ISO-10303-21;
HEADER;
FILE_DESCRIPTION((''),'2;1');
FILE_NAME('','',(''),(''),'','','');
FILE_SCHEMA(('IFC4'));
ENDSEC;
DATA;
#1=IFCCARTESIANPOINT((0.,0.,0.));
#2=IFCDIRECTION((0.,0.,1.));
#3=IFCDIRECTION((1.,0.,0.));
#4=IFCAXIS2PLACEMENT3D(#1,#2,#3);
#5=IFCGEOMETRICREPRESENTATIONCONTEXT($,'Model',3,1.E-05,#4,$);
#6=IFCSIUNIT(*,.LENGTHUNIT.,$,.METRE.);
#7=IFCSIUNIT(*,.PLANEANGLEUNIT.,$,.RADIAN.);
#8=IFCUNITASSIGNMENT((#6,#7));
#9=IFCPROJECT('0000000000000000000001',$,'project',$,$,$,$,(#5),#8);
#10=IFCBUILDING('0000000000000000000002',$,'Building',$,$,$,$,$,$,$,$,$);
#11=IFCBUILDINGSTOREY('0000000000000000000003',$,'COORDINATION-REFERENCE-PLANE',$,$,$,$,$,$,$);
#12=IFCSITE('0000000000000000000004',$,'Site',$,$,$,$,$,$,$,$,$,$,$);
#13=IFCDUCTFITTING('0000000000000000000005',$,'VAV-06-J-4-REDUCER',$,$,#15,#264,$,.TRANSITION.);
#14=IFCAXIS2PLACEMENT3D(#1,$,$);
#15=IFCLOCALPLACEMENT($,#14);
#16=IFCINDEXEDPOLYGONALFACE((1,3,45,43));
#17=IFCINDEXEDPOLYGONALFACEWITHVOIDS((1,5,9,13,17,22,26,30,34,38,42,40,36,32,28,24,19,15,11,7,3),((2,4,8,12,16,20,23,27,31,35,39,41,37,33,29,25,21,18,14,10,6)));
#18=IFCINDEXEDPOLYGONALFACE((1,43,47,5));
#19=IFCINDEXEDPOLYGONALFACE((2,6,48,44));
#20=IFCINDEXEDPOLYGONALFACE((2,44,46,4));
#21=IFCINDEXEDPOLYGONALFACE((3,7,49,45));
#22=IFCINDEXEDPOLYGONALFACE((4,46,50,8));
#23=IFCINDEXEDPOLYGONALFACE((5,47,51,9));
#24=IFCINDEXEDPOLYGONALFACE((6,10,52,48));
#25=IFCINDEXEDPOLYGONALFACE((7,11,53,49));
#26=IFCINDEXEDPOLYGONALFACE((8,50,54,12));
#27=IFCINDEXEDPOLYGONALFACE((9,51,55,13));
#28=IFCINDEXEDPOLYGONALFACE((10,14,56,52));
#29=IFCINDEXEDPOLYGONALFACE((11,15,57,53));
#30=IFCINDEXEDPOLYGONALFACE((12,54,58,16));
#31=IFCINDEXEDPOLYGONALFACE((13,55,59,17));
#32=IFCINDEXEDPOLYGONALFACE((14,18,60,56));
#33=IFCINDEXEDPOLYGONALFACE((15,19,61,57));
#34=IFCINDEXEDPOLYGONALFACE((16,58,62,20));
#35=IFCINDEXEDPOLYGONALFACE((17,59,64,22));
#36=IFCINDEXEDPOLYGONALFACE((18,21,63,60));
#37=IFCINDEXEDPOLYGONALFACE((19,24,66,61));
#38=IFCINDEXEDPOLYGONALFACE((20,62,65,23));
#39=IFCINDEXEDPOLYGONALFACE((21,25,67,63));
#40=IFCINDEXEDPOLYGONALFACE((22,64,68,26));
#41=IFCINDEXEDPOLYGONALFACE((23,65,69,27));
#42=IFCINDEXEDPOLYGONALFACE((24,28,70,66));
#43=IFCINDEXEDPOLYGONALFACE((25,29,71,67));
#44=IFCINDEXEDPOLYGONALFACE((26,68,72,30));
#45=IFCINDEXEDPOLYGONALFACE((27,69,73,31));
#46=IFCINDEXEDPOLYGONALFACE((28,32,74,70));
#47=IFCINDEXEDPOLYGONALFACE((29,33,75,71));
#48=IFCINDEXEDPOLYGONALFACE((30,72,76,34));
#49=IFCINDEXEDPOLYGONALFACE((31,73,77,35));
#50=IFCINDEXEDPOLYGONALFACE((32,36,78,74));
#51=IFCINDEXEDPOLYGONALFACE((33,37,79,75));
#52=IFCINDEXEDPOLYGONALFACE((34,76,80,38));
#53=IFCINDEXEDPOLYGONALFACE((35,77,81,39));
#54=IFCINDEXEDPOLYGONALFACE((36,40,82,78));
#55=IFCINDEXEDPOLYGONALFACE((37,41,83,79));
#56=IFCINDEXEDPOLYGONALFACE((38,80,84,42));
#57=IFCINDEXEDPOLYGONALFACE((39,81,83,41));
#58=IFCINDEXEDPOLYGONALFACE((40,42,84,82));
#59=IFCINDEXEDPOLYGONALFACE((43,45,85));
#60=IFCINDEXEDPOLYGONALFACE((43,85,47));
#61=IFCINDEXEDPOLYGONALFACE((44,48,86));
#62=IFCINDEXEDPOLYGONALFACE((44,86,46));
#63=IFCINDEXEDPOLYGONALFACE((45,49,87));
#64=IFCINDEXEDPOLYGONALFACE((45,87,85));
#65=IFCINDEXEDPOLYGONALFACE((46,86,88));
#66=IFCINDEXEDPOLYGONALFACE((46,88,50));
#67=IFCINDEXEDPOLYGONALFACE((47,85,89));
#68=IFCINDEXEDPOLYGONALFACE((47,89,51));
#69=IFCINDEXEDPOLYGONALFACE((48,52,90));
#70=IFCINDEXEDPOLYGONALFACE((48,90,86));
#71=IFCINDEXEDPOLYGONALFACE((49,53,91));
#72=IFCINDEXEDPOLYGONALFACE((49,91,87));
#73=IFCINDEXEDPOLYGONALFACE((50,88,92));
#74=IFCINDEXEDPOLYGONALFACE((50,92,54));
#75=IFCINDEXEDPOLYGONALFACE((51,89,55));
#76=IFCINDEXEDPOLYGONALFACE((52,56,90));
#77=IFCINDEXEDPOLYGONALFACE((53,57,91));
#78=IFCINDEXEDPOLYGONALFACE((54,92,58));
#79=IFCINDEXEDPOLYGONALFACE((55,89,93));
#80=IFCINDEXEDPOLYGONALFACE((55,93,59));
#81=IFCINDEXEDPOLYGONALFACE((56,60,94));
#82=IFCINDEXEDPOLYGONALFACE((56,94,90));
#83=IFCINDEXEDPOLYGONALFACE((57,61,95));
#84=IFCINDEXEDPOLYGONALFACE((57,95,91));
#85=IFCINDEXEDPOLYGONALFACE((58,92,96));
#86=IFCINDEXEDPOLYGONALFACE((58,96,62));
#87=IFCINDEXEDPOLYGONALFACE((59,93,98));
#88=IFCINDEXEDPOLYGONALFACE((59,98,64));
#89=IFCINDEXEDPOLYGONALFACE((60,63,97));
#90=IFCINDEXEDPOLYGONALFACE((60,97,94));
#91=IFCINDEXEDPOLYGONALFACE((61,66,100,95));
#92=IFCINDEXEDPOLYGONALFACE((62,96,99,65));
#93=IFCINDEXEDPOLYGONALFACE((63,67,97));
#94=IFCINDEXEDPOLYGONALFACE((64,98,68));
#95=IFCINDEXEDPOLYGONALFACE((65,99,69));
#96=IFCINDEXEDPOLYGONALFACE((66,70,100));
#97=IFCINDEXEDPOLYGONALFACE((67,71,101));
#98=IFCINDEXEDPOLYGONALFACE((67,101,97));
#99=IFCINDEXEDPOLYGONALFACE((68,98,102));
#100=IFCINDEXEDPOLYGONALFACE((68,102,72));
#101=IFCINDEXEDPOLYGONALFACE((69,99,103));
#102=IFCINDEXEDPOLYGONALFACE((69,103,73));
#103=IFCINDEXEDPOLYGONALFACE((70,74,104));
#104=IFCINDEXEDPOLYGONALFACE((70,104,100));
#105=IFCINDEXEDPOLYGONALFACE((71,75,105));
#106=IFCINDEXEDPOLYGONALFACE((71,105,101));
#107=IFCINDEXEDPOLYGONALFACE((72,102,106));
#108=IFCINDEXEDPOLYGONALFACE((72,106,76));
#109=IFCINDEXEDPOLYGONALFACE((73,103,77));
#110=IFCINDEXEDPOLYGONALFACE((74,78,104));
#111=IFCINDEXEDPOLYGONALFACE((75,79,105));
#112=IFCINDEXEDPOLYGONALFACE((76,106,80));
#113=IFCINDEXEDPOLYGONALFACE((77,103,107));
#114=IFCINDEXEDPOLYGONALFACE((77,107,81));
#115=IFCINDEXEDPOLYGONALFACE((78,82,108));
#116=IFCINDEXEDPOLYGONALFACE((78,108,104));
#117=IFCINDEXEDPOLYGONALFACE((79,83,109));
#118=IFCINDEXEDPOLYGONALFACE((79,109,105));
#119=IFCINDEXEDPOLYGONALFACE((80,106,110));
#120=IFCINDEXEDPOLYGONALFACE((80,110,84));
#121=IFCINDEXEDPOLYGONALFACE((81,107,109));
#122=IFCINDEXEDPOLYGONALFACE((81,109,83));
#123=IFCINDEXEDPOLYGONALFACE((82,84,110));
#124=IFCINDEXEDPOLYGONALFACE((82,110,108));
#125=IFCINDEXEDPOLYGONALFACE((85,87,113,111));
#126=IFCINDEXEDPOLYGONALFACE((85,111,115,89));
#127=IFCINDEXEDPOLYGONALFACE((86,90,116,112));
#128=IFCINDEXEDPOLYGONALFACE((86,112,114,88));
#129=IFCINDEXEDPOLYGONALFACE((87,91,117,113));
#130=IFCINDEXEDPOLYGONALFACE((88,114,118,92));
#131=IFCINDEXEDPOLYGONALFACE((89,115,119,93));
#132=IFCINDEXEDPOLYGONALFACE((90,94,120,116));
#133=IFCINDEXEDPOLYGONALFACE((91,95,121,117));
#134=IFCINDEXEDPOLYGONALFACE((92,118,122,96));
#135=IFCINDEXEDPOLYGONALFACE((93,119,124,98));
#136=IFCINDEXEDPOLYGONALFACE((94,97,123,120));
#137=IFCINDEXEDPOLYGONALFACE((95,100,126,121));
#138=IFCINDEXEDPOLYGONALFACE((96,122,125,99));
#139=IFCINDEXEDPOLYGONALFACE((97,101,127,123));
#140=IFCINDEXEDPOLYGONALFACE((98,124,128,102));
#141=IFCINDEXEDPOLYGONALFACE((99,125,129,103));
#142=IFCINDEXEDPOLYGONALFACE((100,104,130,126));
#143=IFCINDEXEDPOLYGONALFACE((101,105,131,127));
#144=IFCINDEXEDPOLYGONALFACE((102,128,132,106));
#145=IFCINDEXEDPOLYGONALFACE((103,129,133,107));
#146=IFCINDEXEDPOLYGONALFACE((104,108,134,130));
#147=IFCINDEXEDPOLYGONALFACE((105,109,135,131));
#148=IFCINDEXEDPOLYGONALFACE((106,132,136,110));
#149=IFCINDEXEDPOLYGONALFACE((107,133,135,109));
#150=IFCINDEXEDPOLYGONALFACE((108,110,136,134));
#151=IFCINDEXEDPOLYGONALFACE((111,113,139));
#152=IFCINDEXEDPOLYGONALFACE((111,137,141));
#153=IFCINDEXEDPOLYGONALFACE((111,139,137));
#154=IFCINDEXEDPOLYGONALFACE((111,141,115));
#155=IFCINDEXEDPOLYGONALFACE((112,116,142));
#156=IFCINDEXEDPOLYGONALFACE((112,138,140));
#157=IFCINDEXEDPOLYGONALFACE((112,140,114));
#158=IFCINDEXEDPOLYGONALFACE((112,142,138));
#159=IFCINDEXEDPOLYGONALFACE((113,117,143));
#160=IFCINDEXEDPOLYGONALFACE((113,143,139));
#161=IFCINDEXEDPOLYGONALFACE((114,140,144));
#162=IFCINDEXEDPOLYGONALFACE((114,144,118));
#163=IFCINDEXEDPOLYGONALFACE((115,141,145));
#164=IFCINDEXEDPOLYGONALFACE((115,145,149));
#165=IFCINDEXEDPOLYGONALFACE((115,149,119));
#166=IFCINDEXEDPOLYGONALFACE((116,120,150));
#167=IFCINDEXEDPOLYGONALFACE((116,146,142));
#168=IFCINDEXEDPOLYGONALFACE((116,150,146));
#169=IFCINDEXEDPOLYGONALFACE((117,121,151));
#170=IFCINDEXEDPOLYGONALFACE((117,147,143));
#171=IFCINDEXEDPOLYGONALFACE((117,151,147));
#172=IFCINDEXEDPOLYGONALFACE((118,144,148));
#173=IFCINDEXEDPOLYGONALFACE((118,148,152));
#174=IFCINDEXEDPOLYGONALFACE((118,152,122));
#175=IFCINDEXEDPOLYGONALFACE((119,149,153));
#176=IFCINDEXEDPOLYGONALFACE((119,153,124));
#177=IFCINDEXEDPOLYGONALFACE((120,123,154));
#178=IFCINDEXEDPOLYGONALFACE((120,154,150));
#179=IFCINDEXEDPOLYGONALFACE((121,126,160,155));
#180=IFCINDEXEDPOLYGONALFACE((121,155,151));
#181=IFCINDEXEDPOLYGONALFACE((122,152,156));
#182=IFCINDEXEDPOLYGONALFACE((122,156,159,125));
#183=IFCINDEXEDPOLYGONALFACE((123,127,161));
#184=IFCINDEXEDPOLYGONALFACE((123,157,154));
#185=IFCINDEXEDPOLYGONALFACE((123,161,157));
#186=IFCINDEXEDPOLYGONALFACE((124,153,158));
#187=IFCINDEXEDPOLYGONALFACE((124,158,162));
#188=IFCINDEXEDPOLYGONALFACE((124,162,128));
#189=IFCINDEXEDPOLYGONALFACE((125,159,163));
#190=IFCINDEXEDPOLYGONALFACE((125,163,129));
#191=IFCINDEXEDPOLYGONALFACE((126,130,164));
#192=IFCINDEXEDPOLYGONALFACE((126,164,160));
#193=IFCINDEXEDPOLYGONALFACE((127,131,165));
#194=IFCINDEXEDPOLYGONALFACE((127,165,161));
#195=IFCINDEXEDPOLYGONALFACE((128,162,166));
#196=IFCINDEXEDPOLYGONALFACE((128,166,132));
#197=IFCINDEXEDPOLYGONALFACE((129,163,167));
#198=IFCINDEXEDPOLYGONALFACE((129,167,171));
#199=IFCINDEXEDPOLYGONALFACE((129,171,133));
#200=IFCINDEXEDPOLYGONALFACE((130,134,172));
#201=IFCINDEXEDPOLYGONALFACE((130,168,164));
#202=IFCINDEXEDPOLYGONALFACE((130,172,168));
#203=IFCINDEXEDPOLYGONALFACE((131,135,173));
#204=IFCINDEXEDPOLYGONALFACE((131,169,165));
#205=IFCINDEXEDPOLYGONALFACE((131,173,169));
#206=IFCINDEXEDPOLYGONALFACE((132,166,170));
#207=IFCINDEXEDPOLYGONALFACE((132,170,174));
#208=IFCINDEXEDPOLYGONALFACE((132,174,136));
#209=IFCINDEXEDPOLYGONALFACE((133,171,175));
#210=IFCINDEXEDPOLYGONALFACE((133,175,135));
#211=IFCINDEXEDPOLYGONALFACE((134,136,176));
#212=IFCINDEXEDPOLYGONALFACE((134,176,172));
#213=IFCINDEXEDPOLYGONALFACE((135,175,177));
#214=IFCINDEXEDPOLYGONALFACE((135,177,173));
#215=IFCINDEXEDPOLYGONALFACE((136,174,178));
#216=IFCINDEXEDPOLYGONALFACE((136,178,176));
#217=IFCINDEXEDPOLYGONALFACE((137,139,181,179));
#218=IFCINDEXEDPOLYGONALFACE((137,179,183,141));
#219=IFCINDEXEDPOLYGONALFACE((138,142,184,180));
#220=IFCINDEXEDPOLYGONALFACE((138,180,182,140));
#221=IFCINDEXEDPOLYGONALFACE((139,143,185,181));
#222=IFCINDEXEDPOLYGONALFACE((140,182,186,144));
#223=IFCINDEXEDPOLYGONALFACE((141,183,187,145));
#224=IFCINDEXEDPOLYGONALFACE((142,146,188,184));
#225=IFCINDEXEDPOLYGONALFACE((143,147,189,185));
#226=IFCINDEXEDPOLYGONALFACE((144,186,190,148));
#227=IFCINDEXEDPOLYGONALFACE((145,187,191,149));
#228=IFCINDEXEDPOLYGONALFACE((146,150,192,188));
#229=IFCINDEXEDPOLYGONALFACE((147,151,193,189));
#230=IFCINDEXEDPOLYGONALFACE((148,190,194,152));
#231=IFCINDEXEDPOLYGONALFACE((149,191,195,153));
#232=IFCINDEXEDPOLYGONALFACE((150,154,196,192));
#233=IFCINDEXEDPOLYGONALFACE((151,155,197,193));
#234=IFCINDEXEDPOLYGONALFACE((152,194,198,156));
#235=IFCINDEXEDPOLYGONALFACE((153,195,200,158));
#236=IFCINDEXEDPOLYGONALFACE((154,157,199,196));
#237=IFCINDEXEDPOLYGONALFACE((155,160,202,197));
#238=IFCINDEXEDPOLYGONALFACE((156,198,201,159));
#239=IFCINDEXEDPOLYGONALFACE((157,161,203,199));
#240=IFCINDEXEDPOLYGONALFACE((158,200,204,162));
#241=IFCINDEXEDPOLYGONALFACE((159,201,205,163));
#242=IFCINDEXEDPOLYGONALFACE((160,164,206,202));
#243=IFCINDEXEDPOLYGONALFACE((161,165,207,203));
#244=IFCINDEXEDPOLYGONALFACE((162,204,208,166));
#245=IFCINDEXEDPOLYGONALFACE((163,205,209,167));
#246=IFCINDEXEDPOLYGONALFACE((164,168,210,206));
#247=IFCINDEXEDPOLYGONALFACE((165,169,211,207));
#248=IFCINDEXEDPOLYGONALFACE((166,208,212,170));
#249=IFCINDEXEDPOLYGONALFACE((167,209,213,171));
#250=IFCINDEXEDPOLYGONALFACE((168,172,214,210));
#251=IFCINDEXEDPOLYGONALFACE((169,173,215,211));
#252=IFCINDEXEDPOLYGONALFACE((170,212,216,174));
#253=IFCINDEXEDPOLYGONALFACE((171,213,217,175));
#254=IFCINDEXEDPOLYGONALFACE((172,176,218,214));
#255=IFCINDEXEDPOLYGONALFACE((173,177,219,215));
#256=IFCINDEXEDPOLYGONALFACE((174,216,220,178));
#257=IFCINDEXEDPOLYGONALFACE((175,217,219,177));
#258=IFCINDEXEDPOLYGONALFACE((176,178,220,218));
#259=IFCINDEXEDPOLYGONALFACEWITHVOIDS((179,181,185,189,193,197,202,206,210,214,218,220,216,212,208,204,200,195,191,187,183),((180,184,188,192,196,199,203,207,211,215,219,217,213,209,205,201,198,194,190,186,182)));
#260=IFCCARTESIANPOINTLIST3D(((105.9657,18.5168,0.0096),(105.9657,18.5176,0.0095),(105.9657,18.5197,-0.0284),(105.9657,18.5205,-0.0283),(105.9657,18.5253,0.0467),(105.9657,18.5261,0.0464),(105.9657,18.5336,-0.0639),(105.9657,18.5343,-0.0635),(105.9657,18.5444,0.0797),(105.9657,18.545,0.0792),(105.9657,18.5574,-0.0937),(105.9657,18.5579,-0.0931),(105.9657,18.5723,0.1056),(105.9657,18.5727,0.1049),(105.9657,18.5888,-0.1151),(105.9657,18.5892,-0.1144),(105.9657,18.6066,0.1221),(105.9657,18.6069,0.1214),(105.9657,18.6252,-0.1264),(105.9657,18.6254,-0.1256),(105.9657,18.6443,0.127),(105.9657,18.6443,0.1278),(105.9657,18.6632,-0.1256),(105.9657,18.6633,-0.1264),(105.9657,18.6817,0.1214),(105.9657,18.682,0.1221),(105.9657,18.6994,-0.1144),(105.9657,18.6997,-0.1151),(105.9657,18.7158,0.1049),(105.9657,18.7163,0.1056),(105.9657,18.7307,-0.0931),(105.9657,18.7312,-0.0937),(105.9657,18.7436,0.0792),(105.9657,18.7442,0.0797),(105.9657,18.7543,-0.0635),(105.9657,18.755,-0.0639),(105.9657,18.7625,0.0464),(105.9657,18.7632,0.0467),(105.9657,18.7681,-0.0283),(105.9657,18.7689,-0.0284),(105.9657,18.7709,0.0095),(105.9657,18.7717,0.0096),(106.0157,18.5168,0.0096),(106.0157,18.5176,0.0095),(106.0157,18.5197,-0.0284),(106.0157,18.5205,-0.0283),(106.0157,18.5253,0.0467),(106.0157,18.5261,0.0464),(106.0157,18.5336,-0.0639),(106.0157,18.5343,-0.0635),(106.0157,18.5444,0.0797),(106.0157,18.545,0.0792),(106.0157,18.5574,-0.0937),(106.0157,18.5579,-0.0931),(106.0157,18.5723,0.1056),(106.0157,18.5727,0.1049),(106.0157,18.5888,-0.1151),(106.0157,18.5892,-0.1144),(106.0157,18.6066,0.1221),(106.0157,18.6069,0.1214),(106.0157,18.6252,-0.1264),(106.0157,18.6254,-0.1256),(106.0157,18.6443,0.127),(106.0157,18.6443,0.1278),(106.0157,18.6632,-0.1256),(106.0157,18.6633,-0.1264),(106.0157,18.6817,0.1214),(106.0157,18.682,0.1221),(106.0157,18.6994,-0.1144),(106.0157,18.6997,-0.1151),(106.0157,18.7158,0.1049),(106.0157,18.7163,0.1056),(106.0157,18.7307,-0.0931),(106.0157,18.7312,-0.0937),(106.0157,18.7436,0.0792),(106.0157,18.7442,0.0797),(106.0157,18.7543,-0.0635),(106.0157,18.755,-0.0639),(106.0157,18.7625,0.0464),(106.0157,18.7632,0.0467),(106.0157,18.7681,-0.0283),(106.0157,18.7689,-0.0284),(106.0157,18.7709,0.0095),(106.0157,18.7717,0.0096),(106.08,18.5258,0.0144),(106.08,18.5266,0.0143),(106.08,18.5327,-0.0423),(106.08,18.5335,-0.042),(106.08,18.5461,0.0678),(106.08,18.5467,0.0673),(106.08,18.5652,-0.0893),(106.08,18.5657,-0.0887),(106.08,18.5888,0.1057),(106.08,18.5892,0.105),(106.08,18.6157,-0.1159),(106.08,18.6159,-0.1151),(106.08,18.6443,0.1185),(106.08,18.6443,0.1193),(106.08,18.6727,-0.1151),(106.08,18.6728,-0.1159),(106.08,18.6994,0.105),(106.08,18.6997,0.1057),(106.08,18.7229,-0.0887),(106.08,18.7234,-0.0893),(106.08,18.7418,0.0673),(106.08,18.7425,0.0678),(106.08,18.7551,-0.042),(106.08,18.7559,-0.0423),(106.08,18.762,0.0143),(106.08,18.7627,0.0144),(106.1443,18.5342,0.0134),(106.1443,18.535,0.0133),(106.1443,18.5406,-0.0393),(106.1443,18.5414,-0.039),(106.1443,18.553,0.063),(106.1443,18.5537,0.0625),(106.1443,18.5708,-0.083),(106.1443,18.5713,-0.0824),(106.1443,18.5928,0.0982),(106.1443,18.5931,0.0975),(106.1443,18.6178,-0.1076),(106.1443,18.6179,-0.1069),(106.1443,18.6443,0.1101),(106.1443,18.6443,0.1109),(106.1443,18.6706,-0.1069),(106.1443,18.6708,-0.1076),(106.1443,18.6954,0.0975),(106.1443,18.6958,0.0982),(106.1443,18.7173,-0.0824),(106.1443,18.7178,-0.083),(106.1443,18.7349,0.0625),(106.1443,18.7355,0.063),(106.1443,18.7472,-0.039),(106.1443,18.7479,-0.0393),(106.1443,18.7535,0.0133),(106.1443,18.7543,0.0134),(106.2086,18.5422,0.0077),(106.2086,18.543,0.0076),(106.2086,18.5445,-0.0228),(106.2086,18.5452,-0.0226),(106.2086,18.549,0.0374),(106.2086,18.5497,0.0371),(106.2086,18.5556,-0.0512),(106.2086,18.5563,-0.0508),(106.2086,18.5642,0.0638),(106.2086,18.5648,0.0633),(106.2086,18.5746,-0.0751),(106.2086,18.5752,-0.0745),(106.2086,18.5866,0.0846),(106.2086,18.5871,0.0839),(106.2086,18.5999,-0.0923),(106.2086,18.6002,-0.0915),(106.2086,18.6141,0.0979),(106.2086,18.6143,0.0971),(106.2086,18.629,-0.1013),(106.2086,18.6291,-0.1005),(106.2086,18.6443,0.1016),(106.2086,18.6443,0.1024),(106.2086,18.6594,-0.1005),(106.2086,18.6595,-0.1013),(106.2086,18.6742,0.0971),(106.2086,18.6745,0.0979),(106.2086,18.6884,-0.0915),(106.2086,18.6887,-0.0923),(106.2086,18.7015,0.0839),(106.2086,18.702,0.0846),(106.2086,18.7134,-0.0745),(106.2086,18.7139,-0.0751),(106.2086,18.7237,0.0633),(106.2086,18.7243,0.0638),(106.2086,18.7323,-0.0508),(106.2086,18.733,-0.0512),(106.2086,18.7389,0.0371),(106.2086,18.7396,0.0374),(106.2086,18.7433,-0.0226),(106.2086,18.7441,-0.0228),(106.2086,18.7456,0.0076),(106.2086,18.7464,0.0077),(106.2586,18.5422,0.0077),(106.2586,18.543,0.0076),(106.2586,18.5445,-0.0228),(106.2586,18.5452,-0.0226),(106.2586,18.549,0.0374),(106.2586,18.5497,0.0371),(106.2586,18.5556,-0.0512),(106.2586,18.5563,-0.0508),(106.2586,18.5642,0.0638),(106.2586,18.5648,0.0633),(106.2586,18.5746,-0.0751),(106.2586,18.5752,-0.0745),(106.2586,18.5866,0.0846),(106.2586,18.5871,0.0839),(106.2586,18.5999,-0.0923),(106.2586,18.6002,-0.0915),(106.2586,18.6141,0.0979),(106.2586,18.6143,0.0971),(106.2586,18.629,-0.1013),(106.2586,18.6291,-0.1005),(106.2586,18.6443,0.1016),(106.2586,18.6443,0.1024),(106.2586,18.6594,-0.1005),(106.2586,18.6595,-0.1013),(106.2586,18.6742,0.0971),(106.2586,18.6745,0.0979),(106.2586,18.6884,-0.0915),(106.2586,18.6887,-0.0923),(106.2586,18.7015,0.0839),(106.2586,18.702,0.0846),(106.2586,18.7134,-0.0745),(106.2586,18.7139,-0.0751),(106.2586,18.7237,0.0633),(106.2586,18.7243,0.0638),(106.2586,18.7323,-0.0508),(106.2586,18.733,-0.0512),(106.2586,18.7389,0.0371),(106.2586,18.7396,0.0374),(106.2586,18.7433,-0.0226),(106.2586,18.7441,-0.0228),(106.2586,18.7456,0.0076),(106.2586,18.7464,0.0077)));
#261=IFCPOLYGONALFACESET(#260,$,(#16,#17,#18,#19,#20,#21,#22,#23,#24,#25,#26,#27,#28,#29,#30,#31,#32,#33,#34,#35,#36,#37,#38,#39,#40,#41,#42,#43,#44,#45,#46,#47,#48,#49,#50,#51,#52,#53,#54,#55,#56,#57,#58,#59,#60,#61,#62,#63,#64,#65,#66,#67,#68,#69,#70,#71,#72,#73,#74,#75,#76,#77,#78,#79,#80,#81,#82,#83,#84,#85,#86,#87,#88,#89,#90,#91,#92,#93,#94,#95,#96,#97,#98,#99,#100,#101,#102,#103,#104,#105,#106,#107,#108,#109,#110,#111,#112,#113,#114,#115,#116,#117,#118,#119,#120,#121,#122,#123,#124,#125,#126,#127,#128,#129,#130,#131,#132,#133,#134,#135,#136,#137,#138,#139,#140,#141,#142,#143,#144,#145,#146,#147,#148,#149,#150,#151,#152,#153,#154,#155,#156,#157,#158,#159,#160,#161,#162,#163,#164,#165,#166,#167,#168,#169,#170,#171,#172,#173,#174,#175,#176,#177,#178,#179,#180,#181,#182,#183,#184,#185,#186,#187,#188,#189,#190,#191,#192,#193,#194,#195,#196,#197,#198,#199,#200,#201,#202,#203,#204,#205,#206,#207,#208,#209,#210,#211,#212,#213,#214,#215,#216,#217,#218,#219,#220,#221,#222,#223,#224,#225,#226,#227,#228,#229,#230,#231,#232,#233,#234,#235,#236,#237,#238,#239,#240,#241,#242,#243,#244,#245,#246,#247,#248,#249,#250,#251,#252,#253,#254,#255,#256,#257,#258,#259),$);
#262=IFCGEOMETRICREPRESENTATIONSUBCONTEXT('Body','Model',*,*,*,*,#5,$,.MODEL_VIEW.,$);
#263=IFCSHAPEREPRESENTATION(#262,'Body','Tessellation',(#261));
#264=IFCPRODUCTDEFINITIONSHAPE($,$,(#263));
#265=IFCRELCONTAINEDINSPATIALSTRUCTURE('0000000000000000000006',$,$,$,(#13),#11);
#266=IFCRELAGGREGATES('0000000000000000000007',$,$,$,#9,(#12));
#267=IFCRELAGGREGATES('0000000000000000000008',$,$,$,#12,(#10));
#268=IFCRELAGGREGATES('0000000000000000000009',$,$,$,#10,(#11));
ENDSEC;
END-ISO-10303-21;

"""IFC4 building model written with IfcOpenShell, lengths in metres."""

from ifc_helpers import new_model, entity, si_unit, frame, origin_with_axes, place, context, subcontext, project, spatial, element, save


model = new_model("IFC4")

# Units and contexts
model_context_1 = context("Model", 3, precision=1e-05, world=origin_with_axes())
body_context_1 = subcontext(model_context_1, "Body", "Model", "MODEL_VIEW")
ifc_project = project(units=[si_unit("LENGTHUNIT", "METRE"), si_unit("PLANEANGLEUNIT", "RADIAN")], contexts=[model_context_1])

# Site, building, storey
site = spatial("IfcSite", under=ifc_project, Name="Site")
building = spatial("IfcBuilding", under=site, Name="Building")
storey = spatial("IfcBuildingStorey", under=building, Name="COORDINATION-REFERENCE-PLANE")

# Duct fitting
for number, where, z_axis, x_axis, name in (
    (1, (105.9657, 18.6443, 0.0), (0.0, 1.0, 0.0), (0.0, 0.0, 1.0), "VAV-06-J-4-REDUCER"),
):
    element("IfcDuctFitting", number, at=place(None, frame(where, z_axis=z_axis, x_axis=x_axis)), inside=storey, Name=name, PredefinedType="TRANSITION", context=body_context_1, shape_type="SweptSolid", body=[
        entity("IfcRevolvedAreaSolid", entity("IfcArbitraryClosedProfileDef", "AREA", None, entity("IfcPolyline", [entity("IfcCartesianPoint", [0.1278, 0.0]), entity("IfcCartesianPoint", [0.1278, 0.05]), entity("IfcCartesianPoint", [0.1024, 0.2429]), entity("IfcCartesianPoint", [0.1024, 0.2929]), entity("IfcCartesianPoint", [0.1016, 0.2929]), entity("IfcCartesianPoint", [0.1016, 0.2429]), entity("IfcCartesianPoint", [0.127, 0.05]), entity("IfcCartesianPoint", [0.127, 0.0]), entity("IfcCartesianPoint", [0.1278, 0.0])])), entity("IfcAxis2Placement3D", entity("IfcCartesianPoint", [0.0, 0.0, 0.0])), entity("IfcAxis1Placement", entity("IfcCartesianPoint", [0.0, 0.0, 0.0]), entity("IfcDirection", [0.0, 1.0, 0.0])), 6.283185),
    ])

save(model, "model.ifc")
